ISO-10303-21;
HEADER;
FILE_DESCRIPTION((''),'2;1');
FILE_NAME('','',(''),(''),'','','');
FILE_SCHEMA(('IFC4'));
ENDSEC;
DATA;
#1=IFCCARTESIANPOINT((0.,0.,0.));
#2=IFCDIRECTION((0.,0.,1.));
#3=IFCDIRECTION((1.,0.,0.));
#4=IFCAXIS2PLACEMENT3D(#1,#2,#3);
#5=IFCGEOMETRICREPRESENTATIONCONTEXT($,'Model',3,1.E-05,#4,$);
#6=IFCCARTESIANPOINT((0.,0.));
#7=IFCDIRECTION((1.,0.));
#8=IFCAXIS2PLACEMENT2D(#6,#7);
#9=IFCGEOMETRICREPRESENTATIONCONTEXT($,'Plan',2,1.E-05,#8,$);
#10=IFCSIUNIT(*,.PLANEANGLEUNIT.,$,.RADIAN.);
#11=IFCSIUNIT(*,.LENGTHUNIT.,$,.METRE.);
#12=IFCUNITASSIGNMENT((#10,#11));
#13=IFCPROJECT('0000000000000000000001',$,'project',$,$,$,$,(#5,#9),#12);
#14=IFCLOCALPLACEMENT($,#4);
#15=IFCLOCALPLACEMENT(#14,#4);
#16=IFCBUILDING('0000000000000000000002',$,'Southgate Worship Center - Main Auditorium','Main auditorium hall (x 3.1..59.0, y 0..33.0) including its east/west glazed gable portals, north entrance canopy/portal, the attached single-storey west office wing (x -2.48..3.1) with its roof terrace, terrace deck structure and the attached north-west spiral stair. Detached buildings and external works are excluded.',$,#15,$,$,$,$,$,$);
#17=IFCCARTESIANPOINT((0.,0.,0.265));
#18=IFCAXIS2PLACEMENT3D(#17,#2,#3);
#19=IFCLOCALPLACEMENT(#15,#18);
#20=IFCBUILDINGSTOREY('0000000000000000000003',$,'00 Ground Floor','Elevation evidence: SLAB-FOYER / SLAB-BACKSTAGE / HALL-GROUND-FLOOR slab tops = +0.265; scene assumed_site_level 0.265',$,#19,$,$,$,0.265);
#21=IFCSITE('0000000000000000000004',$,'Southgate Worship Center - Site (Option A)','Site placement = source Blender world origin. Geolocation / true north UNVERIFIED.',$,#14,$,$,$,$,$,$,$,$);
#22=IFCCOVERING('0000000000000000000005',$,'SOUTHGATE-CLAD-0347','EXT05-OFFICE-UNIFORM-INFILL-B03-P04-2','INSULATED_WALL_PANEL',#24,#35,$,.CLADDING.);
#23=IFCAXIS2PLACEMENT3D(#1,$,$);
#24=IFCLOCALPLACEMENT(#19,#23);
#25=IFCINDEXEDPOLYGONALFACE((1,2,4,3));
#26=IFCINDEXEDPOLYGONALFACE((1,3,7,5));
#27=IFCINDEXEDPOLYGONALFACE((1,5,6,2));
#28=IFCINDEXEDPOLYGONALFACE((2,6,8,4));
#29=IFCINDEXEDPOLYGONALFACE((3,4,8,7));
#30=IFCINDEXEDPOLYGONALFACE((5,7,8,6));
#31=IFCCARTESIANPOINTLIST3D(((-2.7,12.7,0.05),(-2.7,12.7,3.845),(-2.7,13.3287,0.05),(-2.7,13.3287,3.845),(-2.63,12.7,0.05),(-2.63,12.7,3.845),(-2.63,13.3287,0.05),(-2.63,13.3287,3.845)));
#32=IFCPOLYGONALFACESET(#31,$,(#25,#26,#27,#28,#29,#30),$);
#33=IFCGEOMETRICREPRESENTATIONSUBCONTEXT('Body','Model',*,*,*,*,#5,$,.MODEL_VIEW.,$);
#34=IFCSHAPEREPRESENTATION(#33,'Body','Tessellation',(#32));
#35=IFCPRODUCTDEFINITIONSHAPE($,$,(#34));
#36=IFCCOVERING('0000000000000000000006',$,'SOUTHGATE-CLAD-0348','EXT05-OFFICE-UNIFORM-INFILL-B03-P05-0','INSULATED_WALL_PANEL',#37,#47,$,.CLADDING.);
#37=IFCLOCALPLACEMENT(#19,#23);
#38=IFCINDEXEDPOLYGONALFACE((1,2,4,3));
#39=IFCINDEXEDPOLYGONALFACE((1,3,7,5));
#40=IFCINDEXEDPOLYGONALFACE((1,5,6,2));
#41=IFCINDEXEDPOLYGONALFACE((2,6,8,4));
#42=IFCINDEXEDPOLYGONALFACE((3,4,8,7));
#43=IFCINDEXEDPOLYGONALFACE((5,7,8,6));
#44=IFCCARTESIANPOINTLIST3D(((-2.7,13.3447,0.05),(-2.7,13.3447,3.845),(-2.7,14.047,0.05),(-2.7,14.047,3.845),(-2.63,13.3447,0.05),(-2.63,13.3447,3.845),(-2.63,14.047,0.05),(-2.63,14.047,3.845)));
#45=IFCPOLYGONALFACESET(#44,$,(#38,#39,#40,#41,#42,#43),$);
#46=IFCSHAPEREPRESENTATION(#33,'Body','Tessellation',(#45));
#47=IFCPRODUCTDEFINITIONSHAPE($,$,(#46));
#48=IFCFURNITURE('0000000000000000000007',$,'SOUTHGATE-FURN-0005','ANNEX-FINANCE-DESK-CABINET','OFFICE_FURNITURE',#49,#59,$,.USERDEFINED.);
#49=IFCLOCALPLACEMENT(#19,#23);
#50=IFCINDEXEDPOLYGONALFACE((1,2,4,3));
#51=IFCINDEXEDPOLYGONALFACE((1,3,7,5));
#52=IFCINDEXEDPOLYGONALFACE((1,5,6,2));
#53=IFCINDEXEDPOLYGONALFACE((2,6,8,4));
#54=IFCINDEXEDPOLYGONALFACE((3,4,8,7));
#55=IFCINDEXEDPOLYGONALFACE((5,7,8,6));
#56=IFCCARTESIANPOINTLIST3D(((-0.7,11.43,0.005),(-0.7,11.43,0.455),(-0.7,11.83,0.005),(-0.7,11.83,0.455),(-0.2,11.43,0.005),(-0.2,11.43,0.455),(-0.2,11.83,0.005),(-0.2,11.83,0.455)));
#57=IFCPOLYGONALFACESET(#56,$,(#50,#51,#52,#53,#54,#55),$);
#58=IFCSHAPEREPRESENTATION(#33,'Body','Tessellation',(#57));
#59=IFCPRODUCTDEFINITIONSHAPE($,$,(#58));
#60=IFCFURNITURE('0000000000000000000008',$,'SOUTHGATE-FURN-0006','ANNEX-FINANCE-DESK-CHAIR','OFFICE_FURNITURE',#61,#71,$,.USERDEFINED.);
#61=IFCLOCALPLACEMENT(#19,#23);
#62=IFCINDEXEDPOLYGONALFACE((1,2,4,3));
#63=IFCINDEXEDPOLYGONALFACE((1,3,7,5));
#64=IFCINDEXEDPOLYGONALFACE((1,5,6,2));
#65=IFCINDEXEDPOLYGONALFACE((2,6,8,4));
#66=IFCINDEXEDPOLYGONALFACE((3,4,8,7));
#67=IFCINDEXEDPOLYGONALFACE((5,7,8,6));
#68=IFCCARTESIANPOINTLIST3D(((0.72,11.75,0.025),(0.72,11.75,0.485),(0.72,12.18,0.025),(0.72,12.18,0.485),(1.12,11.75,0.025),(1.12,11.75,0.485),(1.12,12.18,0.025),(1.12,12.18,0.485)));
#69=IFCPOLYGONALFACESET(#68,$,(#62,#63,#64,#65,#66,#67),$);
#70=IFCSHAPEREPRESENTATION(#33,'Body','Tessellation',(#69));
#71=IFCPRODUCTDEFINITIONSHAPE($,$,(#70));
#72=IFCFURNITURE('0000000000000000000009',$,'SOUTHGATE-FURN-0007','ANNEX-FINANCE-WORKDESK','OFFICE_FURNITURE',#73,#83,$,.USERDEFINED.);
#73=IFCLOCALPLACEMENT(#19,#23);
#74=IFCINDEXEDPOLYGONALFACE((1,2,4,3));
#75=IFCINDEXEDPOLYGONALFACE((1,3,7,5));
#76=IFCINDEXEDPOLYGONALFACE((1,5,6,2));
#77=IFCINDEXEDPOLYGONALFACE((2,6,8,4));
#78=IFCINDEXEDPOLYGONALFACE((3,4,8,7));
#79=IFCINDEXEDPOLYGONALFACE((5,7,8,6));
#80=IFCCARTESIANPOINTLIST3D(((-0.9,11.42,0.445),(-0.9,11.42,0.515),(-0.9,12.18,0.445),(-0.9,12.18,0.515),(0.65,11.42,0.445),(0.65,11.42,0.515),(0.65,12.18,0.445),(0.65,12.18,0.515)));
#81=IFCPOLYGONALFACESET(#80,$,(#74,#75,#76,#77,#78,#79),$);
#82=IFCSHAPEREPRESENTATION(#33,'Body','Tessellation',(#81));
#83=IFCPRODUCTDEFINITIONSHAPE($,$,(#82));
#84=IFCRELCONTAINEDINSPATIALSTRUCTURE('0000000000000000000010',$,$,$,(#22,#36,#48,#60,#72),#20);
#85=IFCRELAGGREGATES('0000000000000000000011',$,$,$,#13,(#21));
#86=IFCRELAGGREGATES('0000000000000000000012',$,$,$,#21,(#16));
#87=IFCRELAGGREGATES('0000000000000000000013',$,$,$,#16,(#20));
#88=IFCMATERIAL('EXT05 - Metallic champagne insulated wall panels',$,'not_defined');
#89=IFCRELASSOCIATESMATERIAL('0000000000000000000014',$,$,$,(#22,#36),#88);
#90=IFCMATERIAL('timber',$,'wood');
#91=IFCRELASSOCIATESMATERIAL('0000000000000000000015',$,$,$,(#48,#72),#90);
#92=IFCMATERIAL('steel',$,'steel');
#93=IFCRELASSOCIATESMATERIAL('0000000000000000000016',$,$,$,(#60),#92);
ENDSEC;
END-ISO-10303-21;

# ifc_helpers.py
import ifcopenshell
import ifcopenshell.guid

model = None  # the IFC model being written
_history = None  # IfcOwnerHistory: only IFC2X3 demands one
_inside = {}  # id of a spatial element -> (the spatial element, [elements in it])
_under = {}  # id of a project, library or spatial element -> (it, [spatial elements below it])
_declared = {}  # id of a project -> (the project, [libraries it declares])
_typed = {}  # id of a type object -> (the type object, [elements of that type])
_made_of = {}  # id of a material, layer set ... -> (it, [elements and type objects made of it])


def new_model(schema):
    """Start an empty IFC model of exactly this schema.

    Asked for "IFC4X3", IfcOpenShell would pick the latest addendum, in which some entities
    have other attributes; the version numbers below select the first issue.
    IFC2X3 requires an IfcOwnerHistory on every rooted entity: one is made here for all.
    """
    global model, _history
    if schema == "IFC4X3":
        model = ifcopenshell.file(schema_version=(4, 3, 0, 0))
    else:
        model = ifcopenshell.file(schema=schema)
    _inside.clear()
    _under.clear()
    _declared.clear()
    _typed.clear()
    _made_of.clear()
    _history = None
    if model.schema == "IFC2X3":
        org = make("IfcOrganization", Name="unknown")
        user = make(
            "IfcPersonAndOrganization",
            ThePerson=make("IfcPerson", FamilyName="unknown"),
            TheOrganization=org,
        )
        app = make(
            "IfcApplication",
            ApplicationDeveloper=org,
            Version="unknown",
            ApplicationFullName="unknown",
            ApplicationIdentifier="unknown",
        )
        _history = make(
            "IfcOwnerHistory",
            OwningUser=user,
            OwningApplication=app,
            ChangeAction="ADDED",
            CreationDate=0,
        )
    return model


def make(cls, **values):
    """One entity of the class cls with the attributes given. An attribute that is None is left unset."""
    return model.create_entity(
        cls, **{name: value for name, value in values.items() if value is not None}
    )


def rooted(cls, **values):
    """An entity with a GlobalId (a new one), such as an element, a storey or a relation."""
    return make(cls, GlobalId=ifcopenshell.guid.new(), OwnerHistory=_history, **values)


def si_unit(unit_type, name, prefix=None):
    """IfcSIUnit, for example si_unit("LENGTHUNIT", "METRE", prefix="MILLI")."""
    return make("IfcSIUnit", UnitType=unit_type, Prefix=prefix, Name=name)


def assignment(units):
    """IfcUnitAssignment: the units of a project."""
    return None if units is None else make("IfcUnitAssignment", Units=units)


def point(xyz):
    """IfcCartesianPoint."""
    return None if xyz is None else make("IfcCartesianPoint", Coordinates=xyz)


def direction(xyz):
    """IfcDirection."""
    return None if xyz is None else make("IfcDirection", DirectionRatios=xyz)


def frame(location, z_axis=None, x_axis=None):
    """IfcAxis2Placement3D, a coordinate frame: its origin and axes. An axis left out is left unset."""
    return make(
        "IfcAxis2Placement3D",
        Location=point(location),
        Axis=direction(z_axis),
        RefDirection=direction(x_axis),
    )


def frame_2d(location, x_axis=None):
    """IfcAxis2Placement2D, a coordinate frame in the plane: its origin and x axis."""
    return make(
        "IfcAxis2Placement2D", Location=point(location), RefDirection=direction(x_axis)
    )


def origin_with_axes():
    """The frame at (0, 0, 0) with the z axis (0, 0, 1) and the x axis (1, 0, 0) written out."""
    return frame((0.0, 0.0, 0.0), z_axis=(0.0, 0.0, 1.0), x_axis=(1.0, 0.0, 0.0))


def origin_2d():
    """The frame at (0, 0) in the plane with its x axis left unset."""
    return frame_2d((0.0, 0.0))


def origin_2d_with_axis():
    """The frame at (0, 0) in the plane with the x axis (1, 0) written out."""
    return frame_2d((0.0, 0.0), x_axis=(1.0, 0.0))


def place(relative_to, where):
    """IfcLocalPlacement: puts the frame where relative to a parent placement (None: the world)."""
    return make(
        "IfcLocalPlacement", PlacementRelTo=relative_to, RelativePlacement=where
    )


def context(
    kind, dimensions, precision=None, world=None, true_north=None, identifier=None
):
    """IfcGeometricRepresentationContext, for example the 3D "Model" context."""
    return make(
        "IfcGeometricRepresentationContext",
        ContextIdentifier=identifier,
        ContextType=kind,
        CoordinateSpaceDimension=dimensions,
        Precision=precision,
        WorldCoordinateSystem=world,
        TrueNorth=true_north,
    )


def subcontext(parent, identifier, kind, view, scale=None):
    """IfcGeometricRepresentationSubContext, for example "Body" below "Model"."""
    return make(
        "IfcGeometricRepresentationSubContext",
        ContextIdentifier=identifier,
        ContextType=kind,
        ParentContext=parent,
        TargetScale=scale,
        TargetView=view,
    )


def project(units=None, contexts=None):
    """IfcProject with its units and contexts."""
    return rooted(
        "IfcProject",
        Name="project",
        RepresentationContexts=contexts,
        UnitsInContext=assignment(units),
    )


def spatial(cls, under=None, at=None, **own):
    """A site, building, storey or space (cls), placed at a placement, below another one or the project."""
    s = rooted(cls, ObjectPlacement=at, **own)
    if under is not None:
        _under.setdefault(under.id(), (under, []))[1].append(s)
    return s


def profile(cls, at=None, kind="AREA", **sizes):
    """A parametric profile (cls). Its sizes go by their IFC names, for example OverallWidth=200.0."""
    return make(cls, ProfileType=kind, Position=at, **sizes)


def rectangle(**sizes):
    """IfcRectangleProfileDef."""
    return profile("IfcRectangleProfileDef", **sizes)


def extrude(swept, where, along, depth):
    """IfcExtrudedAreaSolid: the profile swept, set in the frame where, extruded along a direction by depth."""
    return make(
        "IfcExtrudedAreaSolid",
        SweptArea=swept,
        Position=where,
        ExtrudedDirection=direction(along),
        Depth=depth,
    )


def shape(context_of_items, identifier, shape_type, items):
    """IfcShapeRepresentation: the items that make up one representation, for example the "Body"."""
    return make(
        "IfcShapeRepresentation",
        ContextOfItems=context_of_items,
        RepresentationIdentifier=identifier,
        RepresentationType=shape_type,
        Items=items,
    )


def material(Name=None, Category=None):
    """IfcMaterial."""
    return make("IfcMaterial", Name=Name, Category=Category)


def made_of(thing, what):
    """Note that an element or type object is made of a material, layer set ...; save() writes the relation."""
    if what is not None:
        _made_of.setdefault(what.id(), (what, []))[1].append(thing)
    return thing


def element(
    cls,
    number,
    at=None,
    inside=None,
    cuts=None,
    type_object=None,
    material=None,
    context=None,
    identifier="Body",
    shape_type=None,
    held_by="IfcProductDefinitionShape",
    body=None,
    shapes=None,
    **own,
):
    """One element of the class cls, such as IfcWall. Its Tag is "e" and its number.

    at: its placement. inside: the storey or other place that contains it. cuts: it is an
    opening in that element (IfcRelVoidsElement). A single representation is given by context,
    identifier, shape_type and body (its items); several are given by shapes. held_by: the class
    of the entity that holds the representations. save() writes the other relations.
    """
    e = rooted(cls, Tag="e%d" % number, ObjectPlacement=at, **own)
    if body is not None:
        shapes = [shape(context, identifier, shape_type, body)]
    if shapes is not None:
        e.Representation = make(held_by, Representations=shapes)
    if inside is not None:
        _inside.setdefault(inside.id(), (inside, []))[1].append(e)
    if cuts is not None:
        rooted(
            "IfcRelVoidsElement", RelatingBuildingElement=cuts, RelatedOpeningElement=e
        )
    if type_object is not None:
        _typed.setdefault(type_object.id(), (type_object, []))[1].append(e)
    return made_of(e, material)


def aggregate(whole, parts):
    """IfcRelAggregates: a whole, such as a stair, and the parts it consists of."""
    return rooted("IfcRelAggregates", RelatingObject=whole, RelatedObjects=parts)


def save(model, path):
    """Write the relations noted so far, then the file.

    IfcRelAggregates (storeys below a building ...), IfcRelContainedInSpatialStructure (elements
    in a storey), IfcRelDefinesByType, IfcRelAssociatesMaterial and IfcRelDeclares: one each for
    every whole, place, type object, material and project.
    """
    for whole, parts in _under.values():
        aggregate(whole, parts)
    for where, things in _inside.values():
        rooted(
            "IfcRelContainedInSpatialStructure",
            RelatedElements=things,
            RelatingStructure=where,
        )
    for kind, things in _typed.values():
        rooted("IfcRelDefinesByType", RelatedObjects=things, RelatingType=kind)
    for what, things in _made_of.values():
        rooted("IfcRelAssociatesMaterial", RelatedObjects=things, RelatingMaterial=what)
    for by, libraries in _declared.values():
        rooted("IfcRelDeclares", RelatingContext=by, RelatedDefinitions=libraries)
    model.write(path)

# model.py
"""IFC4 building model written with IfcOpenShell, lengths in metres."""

from ifc_helpers import new_model, si_unit, frame, origin_with_axes, origin_2d, origin_2d_with_axis, place, context, subcontext, project, spatial, rectangle, extrude, material, element, save


model = new_model("IFC4")

# Units and contexts
model_context = context("Model", 3, precision=1e-05, world=origin_with_axes())
plan_context = context("Plan", 2, precision=1e-05, world=origin_2d_with_axis())
body_context = subcontext(model_context, "Body", "Model", "MODEL_VIEW")
ifc_project = project(units=[si_unit("PLANEANGLEUNIT", "RADIAN"), si_unit("LENGTHUNIT", "METRE")], contexts=[model_context, plan_context])

# Site, building, storey
site_placement = place(None, origin_with_axes())
site = spatial("IfcSite", under=ifc_project, at=site_placement, Name="Southgate Worship Center - Site (Option A)", Description="Site placement = source Blender world origin. Geolocation / true north UNVERIFIED.")
building_placement = place(site_placement, origin_with_axes())
building = spatial("IfcBuilding", under=site, at=building_placement, Name="Southgate Worship Center - Main Auditorium", Description="Main auditorium hall (x 3.1..59.0, y 0..33.0) including its east/west glazed gable portals, north entrance canopy/portal, the attached single-storey west office wing (x -2.48..3.1) with its roof terrace, terrace deck structure and the attached north-west spiral stair. Detached buildings and external works are excluded.")
storey_placement = place(building_placement, frame((0.0, 0.0, 0.265), z_axis=(0.0, 0.0, 1.0), x_axis=(1.0, 0.0, 0.0)))
storey = spatial("IfcBuildingStorey", under=building, at=storey_placement, Name="00 Ground Floor", Description="Elevation evidence: SLAB-FOYER / SLAB-BACKSTAGE / HALL-GROUND-FLOOR slab tops = +0.265; scene assumed_site_level 0.265", Elevation=0.265)

# Shared definitions
ifc_material_1 = material(Name="timber", Category="wood")

# Coverings
ifc_material_2 = material(Name="EXT05 - Metallic champagne insulated wall panels", Category="not_defined")
covering_1_placement = place(storey_placement, frame((-2.7, 12.7, 0.05), z_axis=(0.0, 0.0, 1.0), x_axis=(1.0, 0.0, 0.0)))
element("IfcCovering", 1, at=covering_1_placement, inside=storey, material=ifc_material_2, Name="SOUTHGATE-CLAD-0347", Description="EXT05-OFFICE-UNIFORM-INFILL-B03-P04-2", ObjectType="INSULATED_WALL_PANEL", PredefinedType="CLADDING", context=body_context, shape_type="SweptSolid", body=[
    extrude(rectangle(XDim=0.6287, YDim=0.07, at=origin_2d()), frame((0.035, 0.3143, 0.0), z_axis=(0.0, 0.0, 1.0), x_axis=(0.0, 1.0, 0.0)), (0.0, 0.0, 1.0), 3.795),
])
covering_2_placement = place(storey_placement, frame((-2.7, 13.3447, 0.05), z_axis=(0.0, 0.0, 1.0), x_axis=(1.0, 0.0, 0.0)))
element("IfcCovering", 2, at=covering_2_placement, inside=storey, material=ifc_material_2, Name="SOUTHGATE-CLAD-0348", Description="EXT05-OFFICE-UNIFORM-INFILL-B03-P05-0", ObjectType="INSULATED_WALL_PANEL", PredefinedType="CLADDING", context=body_context, shape_type="SweptSolid", body=[
    extrude(rectangle(XDim=0.7023, YDim=0.07, at=origin_2d()), frame((0.035, 0.3511, 0.0), z_axis=(0.0, 0.0, 1.0), x_axis=(0.0, 1.0, 0.0)), (0.0, 0.0, 1.0), 3.795),
])

# Furniture
furniture_1_placement = place(storey_placement, frame((-0.7, 11.43, 0.005), z_axis=(0.0, 0.0, 1.0), x_axis=(1.0, 0.0, 0.0)))
element("IfcFurniture", 3, at=furniture_1_placement, inside=storey, material=ifc_material_1, Name="SOUTHGATE-FURN-0005", Description="ANNEX-FINANCE-DESK-CABINET", ObjectType="OFFICE_FURNITURE", PredefinedType="USERDEFINED", context=body_context, shape_type="SweptSolid", body=[
    extrude(rectangle(XDim=0.4, YDim=0.5, at=origin_2d()), frame((0.25, 0.2, 0.0), z_axis=(0.0, 0.0, 1.0), x_axis=(0.0, -1.0, 0.0)), (0.0, 0.0, 1.0), 0.45),
])
ifc_material_3 = material(Name="steel", Category="steel")
furniture_2_placement = place(storey_placement, frame((0.72, 11.75, 0.025), z_axis=(0.0, 0.0, 1.0), x_axis=(1.0, 0.0, 0.0)))
element("IfcFurniture", 4, at=furniture_2_placement, inside=storey, material=ifc_material_3, Name="SOUTHGATE-FURN-0006", Description="ANNEX-FINANCE-DESK-CHAIR", ObjectType="OFFICE_FURNITURE", PredefinedType="USERDEFINED", context=body_context, shape_type="SweptSolid", body=[
    extrude(rectangle(XDim=0.43, YDim=0.4, at=origin_2d()), frame((0.2, 0.215, 0.0), z_axis=(0.0, 0.0, 1.0), x_axis=(0.0, 1.0, 0.0)), (0.0, 0.0, 1.0), 0.46),
])
furniture_3_placement = place(storey_placement, frame((-0.9, 11.42, 0.445), z_axis=(0.0, 0.0, 1.0), x_axis=(1.0, 0.0, 0.0)))
element("IfcFurniture", 5, at=furniture_3_placement, inside=storey, material=ifc_material_1, Name="SOUTHGATE-FURN-0007", Description="ANNEX-FINANCE-WORKDESK", ObjectType="OFFICE_FURNITURE", PredefinedType="USERDEFINED", context=body_context, shape_type="SweptSolid", body=[
    extrude(rectangle(XDim=0.76, YDim=1.55, at=origin_2d()), frame((0.775, 0.38, 0.0), z_axis=(0.0, 0.0, 1.0), x_axis=(0.0, -1.0, 0.0)), (0.0, 0.0, 1.0), 0.07),
])

save(model, "model.ifc")
